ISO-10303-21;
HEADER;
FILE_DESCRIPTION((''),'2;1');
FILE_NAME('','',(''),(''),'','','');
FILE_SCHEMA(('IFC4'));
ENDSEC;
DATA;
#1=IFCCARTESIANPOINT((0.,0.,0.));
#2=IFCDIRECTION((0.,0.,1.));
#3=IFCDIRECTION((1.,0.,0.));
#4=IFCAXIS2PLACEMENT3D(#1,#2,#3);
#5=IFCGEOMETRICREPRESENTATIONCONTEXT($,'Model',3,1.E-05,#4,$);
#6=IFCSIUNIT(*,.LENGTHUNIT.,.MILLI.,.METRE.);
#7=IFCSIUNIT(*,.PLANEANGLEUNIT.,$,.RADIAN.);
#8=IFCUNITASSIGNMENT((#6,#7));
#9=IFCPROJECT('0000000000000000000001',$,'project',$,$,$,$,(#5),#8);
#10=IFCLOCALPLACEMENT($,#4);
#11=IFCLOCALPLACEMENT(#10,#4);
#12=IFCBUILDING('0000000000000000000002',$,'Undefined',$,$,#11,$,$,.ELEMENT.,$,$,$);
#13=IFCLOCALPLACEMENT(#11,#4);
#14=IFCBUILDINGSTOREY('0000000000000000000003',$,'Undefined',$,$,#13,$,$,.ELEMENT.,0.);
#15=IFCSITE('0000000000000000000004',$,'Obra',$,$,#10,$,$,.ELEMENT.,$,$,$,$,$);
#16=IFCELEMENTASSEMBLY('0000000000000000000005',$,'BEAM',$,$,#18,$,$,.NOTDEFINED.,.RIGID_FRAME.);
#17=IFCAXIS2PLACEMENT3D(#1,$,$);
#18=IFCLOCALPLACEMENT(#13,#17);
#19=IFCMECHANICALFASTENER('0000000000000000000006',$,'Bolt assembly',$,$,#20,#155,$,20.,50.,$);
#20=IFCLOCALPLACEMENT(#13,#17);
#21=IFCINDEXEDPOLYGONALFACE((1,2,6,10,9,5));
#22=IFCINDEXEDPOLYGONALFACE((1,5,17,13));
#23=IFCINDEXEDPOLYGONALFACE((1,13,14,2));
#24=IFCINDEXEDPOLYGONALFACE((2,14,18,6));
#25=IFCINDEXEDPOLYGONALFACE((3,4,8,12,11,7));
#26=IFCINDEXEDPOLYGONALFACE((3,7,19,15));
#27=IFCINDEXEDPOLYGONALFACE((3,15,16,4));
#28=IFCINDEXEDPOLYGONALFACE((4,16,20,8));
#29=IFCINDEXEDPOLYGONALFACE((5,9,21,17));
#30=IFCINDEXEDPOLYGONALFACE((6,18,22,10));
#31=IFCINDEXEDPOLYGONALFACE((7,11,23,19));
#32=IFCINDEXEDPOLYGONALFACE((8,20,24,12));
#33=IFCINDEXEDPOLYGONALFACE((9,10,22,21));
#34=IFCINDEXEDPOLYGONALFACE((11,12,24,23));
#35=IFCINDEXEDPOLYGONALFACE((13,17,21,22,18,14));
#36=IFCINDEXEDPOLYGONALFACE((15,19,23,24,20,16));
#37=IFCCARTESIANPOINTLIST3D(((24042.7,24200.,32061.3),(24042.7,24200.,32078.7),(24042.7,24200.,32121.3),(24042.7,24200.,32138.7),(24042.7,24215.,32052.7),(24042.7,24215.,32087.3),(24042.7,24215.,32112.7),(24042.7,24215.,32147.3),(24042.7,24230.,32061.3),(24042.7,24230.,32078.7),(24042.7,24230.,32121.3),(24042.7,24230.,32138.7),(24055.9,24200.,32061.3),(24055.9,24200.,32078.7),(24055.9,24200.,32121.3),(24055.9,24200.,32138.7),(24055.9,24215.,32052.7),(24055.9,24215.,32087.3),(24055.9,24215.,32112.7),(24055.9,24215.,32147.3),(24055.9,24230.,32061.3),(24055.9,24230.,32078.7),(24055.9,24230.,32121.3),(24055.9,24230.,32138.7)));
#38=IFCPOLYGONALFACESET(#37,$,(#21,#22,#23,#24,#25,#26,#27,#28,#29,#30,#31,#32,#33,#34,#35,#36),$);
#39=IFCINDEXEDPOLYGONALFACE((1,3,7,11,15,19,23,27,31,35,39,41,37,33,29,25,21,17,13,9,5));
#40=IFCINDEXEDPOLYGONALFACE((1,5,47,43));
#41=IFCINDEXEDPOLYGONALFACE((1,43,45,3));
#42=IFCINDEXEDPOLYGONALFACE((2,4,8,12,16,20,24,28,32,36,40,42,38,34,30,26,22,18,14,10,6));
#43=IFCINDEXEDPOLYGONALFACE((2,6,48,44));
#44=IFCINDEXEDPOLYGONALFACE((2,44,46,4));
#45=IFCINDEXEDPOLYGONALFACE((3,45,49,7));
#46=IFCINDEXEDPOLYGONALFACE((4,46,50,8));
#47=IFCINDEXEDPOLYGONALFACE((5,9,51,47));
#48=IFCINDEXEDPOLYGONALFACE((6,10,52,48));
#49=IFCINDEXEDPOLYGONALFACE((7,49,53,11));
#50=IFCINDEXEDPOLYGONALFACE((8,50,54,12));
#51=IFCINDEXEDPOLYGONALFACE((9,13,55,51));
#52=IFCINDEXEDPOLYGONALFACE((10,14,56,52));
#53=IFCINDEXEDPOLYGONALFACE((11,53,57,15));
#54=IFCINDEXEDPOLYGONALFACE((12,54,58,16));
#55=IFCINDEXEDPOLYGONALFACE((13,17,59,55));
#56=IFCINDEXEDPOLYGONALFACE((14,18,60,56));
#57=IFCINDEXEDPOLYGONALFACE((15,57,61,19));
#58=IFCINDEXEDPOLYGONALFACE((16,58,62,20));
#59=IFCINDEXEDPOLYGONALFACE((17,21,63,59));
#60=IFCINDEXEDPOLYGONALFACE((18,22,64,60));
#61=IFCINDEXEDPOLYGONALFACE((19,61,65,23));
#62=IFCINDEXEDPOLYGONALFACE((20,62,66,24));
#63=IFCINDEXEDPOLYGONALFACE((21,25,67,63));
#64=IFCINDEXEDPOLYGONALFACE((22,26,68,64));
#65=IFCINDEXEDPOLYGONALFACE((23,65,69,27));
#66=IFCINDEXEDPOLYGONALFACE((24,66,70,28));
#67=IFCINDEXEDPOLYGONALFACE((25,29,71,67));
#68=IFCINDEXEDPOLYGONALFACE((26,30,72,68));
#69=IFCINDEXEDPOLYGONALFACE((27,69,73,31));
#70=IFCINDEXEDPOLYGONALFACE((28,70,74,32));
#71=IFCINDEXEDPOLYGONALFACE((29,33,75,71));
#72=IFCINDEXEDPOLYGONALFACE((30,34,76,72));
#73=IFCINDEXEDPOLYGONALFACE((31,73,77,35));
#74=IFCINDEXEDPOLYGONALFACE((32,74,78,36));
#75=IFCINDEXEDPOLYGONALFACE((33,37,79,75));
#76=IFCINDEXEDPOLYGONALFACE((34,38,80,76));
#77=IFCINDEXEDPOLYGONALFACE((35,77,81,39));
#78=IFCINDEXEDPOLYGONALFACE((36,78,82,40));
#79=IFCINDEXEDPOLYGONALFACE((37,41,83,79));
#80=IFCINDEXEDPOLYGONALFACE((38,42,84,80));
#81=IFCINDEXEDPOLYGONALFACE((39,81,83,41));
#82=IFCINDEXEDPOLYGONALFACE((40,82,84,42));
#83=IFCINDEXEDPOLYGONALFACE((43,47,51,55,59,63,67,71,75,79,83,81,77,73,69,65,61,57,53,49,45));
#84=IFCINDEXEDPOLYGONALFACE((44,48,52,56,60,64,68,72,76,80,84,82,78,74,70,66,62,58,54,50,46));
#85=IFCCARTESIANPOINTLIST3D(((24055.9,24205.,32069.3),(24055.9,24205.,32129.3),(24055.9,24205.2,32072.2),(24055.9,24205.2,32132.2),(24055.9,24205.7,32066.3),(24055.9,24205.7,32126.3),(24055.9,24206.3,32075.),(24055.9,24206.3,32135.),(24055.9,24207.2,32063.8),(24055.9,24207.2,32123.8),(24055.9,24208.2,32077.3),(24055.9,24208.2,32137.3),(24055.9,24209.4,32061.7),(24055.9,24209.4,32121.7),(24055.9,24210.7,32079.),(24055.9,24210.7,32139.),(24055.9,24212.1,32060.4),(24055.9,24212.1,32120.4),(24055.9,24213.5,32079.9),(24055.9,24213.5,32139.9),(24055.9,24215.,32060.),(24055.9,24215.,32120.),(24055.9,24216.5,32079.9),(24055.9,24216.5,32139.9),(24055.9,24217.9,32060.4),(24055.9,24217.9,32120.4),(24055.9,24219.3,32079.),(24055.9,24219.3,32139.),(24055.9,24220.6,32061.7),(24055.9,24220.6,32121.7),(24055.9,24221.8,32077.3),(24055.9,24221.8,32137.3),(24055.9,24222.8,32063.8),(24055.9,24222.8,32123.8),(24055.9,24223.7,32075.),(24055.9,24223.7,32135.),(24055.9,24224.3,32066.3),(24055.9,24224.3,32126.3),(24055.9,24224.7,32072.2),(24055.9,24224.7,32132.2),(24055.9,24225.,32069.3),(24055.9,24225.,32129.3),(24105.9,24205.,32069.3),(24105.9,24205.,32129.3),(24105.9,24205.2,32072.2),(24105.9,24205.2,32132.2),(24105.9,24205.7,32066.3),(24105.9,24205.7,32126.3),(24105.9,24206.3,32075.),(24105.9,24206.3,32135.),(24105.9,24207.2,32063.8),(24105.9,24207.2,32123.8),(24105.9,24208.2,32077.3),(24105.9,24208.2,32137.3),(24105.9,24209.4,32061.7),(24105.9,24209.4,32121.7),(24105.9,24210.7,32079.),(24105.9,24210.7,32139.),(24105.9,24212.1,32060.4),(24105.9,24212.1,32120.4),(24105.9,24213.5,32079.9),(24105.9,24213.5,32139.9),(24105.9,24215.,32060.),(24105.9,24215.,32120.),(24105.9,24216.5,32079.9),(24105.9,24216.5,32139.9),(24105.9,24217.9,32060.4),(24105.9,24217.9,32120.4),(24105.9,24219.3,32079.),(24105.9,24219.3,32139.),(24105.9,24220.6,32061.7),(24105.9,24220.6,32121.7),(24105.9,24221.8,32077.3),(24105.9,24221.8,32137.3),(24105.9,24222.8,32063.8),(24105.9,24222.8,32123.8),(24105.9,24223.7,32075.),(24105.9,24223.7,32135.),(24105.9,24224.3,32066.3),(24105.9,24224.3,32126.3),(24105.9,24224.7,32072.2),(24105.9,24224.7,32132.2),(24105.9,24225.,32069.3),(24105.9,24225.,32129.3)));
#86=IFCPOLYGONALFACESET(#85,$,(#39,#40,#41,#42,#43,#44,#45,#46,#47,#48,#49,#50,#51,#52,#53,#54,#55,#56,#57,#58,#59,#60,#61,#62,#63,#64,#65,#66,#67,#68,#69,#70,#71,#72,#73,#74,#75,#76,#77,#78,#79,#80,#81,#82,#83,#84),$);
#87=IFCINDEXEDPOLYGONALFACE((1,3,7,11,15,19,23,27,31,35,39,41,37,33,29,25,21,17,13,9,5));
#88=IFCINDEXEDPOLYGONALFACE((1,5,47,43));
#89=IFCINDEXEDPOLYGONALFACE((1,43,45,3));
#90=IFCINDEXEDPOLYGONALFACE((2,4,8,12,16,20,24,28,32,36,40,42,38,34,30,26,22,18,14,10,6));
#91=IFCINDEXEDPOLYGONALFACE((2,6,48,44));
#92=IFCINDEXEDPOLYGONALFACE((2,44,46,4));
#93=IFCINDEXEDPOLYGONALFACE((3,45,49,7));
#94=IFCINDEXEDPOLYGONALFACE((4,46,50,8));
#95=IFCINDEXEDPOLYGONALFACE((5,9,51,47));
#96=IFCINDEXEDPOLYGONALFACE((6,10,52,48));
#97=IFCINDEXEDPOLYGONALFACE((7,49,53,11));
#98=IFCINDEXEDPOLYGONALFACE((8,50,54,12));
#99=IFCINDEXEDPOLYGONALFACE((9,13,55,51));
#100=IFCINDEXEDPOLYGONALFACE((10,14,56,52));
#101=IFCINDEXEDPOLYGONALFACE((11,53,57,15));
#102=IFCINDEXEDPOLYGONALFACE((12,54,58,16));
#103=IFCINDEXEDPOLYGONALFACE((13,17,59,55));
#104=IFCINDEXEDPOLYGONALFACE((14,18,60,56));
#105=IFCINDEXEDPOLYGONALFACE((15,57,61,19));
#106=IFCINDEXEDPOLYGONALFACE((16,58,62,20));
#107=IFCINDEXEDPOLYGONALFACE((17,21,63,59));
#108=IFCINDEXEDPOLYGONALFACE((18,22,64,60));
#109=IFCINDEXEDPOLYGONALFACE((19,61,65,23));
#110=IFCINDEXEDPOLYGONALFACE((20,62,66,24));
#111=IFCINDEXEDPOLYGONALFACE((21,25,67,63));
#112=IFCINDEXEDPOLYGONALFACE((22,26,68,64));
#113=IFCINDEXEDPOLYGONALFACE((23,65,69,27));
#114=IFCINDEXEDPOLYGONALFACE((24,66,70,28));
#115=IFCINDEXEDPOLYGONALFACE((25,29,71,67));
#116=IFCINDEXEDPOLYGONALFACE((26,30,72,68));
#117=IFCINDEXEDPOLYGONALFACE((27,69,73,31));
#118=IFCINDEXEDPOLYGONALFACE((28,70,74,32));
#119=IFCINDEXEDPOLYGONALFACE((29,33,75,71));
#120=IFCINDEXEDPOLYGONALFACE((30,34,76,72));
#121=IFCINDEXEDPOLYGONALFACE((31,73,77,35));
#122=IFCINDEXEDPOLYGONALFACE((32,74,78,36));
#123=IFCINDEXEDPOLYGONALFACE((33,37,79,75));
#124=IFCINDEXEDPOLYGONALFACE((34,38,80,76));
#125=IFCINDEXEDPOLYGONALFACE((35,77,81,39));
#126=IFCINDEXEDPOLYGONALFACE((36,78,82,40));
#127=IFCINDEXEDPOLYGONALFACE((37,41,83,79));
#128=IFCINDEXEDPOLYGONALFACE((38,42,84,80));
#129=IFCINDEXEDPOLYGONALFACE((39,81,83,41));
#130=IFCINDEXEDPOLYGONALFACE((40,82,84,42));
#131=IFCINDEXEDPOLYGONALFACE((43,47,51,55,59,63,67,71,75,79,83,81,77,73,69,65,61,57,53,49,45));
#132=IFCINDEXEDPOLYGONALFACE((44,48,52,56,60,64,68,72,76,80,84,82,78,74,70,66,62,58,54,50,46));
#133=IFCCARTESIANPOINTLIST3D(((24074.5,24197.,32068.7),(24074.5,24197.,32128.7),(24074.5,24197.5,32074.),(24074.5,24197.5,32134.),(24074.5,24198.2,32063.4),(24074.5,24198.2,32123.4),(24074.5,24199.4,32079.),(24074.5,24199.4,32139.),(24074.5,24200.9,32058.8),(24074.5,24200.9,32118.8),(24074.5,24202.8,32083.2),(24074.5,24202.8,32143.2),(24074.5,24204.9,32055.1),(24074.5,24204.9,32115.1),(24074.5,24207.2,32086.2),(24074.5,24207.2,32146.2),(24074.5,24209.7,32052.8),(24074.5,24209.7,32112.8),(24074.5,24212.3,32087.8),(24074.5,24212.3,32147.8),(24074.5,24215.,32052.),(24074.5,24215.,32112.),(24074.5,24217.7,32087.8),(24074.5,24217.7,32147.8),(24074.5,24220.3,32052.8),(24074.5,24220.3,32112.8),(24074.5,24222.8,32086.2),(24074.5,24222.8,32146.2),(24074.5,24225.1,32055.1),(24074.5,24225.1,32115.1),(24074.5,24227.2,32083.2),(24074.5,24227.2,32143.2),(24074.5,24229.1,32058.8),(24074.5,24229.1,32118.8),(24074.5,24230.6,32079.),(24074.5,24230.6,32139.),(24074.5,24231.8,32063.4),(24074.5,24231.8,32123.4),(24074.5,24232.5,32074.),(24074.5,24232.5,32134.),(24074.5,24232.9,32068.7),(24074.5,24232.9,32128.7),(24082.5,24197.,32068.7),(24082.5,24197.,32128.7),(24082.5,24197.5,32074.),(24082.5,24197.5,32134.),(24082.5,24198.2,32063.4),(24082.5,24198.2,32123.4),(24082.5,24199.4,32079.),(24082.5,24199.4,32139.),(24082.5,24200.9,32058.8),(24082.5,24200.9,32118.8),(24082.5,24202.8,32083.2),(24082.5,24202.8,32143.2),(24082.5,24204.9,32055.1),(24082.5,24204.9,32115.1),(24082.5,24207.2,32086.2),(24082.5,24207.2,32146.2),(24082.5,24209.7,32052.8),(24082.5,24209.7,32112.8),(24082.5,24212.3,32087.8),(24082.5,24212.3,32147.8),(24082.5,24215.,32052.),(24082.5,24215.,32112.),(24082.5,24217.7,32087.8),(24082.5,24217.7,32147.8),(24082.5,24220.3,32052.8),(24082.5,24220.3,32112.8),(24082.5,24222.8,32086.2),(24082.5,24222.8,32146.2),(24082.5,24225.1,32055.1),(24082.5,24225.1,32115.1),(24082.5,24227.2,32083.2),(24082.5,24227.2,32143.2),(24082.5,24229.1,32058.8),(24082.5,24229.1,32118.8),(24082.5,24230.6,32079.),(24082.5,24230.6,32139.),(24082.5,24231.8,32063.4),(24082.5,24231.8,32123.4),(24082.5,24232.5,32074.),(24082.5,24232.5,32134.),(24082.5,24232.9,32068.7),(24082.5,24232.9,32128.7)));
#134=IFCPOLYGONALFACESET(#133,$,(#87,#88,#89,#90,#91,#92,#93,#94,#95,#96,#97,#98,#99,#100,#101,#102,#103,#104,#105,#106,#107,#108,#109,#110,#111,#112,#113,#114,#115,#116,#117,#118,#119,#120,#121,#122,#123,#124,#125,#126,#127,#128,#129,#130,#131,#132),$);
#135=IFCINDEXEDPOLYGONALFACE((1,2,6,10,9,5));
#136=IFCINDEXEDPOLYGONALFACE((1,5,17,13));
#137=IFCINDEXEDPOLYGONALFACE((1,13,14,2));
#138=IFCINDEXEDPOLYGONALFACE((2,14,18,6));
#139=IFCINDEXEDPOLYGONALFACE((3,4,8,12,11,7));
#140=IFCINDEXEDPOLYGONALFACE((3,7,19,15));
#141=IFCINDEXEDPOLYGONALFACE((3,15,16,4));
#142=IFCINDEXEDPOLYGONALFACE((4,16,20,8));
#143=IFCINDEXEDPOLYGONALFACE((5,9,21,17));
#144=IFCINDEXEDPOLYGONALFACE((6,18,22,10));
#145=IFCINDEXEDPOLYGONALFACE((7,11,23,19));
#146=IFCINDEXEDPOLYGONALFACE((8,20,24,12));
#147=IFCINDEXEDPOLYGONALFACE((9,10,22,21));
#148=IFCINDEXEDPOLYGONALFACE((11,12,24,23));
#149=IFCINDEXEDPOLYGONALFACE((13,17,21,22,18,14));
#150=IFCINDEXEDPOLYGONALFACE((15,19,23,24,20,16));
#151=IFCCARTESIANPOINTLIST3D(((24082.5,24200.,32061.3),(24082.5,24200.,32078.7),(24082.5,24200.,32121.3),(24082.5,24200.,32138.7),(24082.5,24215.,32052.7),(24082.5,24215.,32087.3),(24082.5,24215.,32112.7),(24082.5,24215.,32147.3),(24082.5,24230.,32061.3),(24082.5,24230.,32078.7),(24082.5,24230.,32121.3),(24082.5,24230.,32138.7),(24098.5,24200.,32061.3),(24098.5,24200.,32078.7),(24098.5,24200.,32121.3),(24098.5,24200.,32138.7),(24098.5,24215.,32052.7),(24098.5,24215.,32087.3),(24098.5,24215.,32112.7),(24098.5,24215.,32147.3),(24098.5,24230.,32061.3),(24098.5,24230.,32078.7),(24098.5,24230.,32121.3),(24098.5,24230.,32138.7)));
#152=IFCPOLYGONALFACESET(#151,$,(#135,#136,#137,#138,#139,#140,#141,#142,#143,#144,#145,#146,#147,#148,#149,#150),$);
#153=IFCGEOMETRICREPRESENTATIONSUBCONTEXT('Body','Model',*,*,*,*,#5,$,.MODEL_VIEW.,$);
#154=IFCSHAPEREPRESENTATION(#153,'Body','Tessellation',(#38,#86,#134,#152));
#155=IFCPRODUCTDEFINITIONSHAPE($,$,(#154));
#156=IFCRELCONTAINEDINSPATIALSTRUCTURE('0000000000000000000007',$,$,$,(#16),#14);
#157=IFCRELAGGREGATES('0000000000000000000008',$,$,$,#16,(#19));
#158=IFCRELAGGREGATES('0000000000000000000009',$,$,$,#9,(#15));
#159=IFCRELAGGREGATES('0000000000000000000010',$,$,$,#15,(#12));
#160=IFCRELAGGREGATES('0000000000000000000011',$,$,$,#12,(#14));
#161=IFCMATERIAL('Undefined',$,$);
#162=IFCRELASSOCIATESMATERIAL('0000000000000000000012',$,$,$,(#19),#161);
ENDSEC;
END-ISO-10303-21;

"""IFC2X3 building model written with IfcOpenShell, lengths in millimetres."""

from ifc_helpers import new_model, si_unit, frame, origin_with_axes, origin_2d_with_axis, place, context, subcontext, project, spatial, polyline, circle, outline, extrude, source, transform, mapped, material, element, aggregate, save


model = new_model("IFC2X3")

# Units and contexts
model_context = context("Model", 3, precision=1e-05, world=origin_with_axes())
body_context = subcontext(model_context, "Body", "Model", "MODEL_VIEW")
ifc_project = project(units=[si_unit("LENGTHUNIT", "METRE", prefix="MILLI"), si_unit("PLANEANGLEUNIT", "RADIAN")], contexts=[model_context])

# Site, building, storey
site_placement = place(None, origin_with_axes())
site = spatial("IfcSite", under=ifc_project, at=site_placement, Name="Obra", CompositionType="ELEMENT")
building_placement = place(site_placement, origin_with_axes())
building = spatial("IfcBuilding", under=site, at=building_placement, Name="Undefined", CompositionType="ELEMENT")
storey_placement = place(building_placement, origin_with_axes())
storey = spatial("IfcBuildingStorey", under=building, at=storey_placement, Name="Undefined", CompositionType="ELEMENT", Elevation=0.0)

# Element assembly
assembly_1_placement = place(storey_placement, origin_with_axes())
assembly_1 = element("IfcElementAssembly", 1, at=assembly_1_placement, inside=storey, Name="BEAM", AssemblyPlace="NOTDEFINED", PredefinedType="RIGID_FRAME")
ifc_material_1 = material(Name="Undefined")

# Mechanical fastener
shared_shape_1 = source(origin_with_axes(), body_context, "Body", "SweptSolid", [
    extrude(outline(polyline([(17.3, 0.0), (8.7, 15.0), (-8.7, 15.0), (-17.3, 0.0), (-8.7, -15.0), (8.7, -15.0), (17.3, 0.0)])), frame((0.0, -27.5, 0.0), z_axis=(0.0, 1.0, 0.0), x_axis=(1.0, 0.0, 0.0)), (0.0, 0.0, 1.0), 13.2),
    extrude(circle(Radius=10.0, at=origin_2d_with_axis()), frame((0.0, -14.3, 0.0), z_axis=(0.0, 1.0, 0.0), x_axis=(1.0, 0.0, 0.0)), (0.0, 0.0, 1.0), 50.0),
    extrude(circle(Radius=18.0, at=origin_2d_with_axis()), frame((0.0, 4.3, 0.0), z_axis=(0.0, 1.0, 0.0), x_axis=(1.0, 0.0, 0.0)), (0.0, 0.0, 1.0), 8.0),
    extrude(outline(polyline([(17.3, 0.0), (8.7, 15.0), (-8.7, 15.0), (-17.3, 0.0), (-8.7, -15.0), (8.7, -15.0), (17.3, 0.0)])), frame((0.0, 12.3, 0.0), z_axis=(0.0, 1.0, 0.0), x_axis=(1.0, 0.0, 0.0)), (0.0, 0.0, 1.0), 16.0),
])
mechanical_fastener_1_placement = place(assembly_1_placement, frame((24070.2, 24255.0, 32170.0), z_axis=(0.000001, -1.0, 0.0), x_axis=(0.0, 0.0, -1.0)))
mechanical_fastener_1 = element("IfcMechanicalFastener", 2, at=mechanical_fastener_1_placement, material=ifc_material_1, Name="Bolt assembly", NominalDiameter=20.0, NominalLength=50.0, context=body_context, shape_type="MappedRepresentation", body=[
    mapped(shared_shape_1, transform((40.0, 0.0, 40.0))),
    mapped(shared_shape_1, transform((100.0, 0.0, 40.0))),
])
aggregate(assembly_1, [mechanical_fastener_1])

save(model, "model.ifc")
